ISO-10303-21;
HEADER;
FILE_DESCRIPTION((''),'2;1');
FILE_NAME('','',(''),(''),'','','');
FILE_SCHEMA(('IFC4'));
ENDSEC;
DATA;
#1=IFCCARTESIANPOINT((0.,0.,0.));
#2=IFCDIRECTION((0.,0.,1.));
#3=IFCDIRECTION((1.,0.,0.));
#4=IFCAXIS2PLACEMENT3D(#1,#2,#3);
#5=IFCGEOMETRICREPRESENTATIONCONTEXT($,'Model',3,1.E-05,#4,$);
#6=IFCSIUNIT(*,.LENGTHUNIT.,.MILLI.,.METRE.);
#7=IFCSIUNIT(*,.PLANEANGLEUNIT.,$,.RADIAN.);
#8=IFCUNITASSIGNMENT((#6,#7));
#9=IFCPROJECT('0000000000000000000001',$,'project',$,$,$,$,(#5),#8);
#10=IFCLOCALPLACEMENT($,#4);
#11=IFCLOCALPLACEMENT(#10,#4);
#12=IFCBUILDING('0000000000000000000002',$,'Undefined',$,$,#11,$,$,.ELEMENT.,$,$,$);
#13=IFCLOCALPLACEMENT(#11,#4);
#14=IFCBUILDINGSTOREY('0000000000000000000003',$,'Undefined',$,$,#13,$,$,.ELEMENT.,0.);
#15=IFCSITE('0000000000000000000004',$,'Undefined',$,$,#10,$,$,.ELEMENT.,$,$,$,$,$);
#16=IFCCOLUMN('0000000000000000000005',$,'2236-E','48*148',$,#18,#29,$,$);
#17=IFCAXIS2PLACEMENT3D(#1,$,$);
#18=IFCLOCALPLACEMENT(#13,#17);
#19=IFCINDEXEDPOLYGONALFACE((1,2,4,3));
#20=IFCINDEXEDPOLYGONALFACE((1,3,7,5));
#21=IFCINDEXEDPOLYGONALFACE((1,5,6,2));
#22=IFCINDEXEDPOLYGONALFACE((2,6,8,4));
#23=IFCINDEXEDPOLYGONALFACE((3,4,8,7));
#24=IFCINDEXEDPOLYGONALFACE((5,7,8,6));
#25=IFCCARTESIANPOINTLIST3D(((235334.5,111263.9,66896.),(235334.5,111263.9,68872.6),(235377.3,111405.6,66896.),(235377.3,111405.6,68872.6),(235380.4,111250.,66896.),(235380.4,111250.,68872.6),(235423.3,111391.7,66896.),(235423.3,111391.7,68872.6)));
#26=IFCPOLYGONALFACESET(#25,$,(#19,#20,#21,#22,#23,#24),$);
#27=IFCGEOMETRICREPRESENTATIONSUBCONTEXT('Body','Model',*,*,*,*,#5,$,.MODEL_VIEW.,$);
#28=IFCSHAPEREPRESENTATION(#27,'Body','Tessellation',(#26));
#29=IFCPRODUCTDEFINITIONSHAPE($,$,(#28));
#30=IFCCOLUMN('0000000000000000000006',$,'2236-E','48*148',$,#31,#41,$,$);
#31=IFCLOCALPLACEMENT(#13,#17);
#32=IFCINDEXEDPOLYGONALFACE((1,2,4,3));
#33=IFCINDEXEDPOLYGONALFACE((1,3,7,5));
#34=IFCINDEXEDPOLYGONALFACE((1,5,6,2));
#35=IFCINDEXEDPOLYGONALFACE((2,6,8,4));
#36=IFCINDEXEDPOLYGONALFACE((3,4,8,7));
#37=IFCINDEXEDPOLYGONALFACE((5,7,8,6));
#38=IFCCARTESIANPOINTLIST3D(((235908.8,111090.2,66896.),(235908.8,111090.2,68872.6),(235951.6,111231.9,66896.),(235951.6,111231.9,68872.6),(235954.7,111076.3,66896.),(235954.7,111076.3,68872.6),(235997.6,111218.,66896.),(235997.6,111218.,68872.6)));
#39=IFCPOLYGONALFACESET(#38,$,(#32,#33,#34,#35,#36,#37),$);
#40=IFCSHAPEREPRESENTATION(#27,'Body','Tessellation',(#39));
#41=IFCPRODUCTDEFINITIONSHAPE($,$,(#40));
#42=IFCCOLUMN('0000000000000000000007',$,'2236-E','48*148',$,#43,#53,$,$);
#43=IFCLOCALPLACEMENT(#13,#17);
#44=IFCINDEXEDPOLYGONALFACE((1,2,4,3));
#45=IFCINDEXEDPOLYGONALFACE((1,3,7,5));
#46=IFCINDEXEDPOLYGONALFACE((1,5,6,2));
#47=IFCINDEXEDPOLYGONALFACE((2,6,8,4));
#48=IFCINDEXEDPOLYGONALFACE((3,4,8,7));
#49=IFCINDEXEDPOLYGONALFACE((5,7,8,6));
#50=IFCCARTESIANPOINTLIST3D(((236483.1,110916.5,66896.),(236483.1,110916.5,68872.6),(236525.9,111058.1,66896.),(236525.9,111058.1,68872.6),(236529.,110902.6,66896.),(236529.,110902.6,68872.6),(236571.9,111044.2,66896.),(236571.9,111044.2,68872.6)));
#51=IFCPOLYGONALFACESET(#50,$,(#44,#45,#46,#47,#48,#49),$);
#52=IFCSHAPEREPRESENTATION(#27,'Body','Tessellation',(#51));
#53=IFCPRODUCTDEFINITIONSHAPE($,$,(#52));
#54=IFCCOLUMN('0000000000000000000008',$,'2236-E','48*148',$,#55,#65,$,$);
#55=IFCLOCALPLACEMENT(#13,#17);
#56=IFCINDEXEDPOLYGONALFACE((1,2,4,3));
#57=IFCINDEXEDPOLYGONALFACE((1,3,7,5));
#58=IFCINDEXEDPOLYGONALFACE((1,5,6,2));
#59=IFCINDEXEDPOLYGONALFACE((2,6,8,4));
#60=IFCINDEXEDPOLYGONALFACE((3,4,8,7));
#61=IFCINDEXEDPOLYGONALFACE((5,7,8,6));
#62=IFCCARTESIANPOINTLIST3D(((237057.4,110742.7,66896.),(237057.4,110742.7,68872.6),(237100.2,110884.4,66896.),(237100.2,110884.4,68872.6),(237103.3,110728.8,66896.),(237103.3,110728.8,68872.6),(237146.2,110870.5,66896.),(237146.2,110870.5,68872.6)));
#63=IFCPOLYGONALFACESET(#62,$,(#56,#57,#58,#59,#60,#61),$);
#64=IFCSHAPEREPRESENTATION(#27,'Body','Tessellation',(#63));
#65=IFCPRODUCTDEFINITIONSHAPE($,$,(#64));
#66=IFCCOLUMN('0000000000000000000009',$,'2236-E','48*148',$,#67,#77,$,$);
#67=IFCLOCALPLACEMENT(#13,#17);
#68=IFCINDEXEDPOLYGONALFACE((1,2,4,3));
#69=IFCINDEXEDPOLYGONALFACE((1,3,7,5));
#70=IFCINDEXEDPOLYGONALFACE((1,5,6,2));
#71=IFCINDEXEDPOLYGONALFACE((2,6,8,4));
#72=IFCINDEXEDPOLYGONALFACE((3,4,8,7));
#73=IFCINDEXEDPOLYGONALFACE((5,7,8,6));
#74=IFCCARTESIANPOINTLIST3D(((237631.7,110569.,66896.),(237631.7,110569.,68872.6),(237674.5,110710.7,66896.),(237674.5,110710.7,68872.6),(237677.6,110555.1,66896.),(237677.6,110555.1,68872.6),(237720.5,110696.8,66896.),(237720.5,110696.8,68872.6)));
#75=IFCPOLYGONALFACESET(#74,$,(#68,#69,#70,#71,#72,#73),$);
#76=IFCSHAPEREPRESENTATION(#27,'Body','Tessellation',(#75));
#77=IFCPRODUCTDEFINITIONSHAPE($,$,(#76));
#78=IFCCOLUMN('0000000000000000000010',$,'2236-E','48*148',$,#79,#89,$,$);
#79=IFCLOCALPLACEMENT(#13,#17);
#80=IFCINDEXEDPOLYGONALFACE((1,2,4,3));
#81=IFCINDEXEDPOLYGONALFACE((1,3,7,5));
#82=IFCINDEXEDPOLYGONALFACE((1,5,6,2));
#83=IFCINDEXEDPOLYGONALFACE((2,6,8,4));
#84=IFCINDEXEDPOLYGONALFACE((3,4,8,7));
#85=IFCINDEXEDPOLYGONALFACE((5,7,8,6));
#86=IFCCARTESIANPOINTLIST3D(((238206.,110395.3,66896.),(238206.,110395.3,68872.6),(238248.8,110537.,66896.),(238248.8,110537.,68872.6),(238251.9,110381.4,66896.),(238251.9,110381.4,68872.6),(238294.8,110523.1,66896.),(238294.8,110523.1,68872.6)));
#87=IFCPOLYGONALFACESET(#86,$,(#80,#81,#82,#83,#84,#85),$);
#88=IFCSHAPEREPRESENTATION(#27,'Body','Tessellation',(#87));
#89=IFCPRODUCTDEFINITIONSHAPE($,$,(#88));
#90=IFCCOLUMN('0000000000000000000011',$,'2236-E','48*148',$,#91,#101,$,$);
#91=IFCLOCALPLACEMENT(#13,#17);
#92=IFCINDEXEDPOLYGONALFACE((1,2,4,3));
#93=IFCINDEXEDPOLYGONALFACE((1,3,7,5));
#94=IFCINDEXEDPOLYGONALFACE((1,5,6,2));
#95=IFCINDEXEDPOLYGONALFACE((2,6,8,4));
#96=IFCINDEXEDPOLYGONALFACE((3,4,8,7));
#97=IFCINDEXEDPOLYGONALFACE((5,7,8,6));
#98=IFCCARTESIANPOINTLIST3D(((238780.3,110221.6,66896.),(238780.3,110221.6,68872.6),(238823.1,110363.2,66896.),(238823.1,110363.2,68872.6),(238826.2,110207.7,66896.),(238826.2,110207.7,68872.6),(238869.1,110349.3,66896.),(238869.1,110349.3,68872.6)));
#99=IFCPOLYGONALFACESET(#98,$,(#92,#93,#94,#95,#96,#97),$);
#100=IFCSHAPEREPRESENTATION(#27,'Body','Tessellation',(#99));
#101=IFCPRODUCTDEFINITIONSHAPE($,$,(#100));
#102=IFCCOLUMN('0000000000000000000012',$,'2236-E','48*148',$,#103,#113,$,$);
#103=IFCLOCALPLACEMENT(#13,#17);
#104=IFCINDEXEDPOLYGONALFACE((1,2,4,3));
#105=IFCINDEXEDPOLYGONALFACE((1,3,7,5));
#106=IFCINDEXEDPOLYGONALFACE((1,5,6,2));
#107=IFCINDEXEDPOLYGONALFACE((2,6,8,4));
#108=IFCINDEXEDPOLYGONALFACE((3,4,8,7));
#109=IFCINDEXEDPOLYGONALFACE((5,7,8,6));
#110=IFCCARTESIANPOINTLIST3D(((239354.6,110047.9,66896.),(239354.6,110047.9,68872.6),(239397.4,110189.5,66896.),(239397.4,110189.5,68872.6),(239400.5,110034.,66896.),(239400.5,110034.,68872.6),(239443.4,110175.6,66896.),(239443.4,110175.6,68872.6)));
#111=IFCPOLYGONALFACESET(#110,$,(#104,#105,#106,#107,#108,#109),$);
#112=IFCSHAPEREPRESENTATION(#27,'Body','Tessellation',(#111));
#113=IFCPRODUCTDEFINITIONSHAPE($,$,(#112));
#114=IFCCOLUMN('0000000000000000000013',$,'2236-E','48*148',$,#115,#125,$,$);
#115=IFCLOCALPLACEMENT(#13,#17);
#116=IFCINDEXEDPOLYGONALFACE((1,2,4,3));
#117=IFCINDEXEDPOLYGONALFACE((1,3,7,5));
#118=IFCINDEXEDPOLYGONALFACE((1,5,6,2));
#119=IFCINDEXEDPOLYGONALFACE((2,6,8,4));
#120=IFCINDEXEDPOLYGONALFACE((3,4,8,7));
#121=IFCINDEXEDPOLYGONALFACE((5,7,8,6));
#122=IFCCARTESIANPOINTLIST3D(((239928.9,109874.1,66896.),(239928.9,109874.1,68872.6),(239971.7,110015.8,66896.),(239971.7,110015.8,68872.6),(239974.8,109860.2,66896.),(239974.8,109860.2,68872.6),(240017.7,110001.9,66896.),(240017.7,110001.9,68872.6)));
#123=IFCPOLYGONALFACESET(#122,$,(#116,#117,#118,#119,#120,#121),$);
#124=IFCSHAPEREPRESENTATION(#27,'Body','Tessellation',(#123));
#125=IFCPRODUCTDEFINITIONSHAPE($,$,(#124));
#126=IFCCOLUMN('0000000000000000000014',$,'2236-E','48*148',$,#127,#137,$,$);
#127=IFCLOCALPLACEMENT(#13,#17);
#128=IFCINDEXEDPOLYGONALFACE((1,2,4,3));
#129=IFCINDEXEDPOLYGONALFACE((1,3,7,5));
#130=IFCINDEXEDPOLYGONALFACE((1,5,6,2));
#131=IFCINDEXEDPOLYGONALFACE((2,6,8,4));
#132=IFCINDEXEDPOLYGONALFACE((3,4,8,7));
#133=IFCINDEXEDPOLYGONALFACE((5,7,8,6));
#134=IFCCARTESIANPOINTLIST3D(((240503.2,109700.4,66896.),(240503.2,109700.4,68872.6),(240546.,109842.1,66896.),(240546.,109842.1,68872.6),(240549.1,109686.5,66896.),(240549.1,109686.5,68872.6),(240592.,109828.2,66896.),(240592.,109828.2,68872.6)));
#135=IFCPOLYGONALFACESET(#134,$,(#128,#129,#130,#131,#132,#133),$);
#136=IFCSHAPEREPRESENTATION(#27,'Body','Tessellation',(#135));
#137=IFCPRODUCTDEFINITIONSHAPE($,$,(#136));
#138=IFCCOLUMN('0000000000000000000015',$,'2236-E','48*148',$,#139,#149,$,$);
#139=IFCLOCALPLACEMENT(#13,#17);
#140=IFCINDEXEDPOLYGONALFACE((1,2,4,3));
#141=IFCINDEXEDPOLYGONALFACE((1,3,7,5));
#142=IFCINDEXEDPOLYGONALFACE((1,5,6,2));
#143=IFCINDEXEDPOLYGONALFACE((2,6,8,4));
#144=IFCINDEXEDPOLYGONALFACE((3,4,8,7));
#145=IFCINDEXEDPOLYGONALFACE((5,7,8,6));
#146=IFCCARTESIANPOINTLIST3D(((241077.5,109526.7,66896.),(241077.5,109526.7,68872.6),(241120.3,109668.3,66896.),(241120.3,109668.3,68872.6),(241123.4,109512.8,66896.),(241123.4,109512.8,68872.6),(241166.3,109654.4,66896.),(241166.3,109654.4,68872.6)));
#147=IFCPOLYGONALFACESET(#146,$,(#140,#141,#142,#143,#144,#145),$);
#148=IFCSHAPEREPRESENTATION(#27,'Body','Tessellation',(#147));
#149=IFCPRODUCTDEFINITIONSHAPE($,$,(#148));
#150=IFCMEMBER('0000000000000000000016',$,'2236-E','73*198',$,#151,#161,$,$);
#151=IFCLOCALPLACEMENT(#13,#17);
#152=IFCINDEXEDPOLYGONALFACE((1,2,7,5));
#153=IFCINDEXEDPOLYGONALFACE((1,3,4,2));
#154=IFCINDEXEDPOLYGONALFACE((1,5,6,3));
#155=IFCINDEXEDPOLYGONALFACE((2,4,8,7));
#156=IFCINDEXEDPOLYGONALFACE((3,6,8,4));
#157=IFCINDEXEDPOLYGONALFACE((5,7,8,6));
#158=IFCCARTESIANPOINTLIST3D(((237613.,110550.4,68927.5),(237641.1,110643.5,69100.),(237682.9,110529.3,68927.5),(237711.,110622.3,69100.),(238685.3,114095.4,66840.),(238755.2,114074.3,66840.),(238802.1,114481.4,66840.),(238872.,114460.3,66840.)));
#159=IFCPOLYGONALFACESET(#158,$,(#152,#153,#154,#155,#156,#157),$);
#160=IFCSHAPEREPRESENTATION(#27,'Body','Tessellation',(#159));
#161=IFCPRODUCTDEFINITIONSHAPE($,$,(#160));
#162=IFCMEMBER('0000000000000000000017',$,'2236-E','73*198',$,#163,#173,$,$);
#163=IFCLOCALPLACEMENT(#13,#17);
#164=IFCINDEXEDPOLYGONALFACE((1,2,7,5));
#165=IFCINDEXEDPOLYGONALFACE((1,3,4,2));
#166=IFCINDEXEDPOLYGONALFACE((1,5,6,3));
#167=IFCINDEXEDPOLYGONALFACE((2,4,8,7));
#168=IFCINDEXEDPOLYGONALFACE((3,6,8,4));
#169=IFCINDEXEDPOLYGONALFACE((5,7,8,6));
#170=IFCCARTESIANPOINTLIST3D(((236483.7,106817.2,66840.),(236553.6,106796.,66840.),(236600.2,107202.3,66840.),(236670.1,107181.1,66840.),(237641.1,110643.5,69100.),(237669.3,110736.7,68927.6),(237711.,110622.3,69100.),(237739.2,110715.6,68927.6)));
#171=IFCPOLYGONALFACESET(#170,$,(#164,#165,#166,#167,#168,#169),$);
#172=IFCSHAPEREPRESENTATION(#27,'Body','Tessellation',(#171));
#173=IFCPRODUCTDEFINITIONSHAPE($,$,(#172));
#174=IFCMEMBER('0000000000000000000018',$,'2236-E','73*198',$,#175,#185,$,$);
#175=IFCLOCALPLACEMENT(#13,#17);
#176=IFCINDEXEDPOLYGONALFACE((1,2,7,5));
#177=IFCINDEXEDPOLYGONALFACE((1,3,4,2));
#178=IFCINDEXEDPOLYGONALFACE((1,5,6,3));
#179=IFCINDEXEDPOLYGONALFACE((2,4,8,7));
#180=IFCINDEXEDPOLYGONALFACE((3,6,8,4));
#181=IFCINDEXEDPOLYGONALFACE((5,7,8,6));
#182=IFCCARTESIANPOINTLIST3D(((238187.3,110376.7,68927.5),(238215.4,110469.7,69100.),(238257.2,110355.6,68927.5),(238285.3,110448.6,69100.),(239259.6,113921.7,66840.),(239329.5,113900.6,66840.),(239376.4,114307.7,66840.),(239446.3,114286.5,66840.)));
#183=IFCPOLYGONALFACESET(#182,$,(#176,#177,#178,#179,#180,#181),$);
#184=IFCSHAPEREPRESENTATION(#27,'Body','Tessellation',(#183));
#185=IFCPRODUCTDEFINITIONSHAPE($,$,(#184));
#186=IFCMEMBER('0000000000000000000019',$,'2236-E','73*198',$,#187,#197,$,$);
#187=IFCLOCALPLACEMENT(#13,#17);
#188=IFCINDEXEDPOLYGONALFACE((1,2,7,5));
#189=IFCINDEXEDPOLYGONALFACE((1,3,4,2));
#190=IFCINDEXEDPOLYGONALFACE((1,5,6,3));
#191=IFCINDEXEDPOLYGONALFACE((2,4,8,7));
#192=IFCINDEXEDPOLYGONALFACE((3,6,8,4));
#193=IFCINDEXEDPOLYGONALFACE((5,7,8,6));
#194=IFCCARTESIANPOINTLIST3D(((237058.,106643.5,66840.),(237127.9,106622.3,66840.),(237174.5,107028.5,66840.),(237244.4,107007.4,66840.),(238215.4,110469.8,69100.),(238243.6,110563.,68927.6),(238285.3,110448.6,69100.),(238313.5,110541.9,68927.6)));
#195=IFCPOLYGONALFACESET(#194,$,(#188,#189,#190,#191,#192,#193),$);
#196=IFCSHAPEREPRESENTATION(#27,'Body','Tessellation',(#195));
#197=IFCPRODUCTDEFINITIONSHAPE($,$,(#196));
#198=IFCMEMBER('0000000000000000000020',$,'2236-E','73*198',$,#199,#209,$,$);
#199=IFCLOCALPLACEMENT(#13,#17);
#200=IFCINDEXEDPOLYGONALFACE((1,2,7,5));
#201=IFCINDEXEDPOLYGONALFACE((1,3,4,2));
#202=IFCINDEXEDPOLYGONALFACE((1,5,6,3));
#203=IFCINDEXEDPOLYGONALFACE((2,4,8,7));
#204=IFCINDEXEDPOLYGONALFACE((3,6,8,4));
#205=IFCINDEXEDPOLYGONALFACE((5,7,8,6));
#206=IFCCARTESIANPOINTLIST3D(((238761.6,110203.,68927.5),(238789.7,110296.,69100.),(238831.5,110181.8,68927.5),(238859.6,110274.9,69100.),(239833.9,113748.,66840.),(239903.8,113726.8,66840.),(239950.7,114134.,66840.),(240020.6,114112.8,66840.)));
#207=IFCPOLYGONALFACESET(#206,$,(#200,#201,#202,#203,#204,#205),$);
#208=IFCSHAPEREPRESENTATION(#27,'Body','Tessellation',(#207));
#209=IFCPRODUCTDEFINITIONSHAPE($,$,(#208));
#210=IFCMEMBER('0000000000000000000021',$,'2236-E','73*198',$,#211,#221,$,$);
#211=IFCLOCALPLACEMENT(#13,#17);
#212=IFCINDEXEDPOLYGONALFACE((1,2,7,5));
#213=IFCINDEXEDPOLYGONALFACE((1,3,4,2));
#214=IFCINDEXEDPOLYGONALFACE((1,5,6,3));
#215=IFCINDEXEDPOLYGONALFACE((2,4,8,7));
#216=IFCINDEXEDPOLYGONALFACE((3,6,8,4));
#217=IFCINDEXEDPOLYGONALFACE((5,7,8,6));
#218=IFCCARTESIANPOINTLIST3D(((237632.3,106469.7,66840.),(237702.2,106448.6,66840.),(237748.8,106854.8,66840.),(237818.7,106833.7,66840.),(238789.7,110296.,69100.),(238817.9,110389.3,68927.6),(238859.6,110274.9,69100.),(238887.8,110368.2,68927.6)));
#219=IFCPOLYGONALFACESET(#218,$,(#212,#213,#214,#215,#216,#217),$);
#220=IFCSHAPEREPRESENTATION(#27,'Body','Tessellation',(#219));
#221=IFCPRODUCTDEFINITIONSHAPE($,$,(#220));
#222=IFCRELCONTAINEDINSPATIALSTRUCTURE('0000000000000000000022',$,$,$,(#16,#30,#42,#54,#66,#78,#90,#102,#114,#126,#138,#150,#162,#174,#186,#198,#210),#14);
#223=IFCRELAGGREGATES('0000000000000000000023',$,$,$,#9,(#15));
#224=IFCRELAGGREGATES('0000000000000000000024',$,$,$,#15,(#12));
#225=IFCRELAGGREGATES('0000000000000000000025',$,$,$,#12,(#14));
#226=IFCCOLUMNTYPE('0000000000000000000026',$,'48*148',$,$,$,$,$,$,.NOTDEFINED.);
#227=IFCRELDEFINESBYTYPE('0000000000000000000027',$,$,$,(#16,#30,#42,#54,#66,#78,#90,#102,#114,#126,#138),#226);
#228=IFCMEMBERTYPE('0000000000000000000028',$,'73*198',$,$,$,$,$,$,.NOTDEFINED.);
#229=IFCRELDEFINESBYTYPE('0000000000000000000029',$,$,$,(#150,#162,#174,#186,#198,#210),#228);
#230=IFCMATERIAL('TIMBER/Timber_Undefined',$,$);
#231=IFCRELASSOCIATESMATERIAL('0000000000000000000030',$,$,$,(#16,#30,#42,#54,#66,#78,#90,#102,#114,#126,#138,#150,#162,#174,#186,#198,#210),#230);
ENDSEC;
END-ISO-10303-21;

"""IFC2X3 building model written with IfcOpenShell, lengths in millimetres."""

from ifc_helpers import new_model, si_unit, frame, origin_with_axes, origin_2d_with_axis, place, context, subcontext, project, spatial, rectangle, extrude, clip, halfspace, material, type_object, element, save


model = new_model("IFC2X3")

# Units and contexts
model_context = context("Model", 3, precision=1e-05, world=origin_with_axes())
body_context = subcontext(model_context, "Body", "Model", "MODEL_VIEW")
ifc_project = project(units=[si_unit("LENGTHUNIT", "METRE", prefix="MILLI"), si_unit("PLANEANGLEUNIT", "RADIAN")], contexts=[model_context])

# Site, building, storey
site_placement = place(None, origin_with_axes())
site = spatial("IfcSite", under=ifc_project, at=site_placement, Name="Undefined", CompositionType="ELEMENT")
building_placement = place(site_placement, origin_with_axes())
building = spatial("IfcBuilding", under=site, at=building_placement, Name="Undefined", CompositionType="ELEMENT")
storey_placement = place(building_placement, origin_with_axes())
storey = spatial("IfcBuildingStorey", under=building, at=storey_placement, Name="Undefined", CompositionType="ELEMENT", Elevation=0.0)

# Columns
ifc_material = material(Name="TIMBER/Timber_Undefined")
column_type = type_object("IfcColumnType", Name="48*148", PredefinedType="NOTDEFINED")
for number, where, z_axis, x_axis, name in (
    (1, (235378.9, 111327.8, 68872.6), (0.0, 0.0, -1.0), (0.957167, -0.289538, 0.0), "2236-E"),
    (2, (235953.2, 111154.1, 68872.6), (0.0, 0.0, -1.0), (0.957167, -0.289538, 0.0), "2236-E"),
    (3, (236527.5, 110980.3, 68872.6), (0.0, 0.0, -1.0), (0.957167, -0.289538, 0.0), "2236-E"),
    (4, (237101.8, 110806.6, 68872.6), (0.0, 0.0, -1.0), (0.957167, -0.289538, 0.0), "2236-E"),
    (5, (237676.1, 110632.9, 68872.6), (0.0, 0.0, -1.0), (0.957167, -0.289538, 0.0), "2236-E"),
    (6, (238250.4, 110459.2, 68872.6), (0.0, 0.0, -1.0), (0.957167, -0.289538, 0.0), "2236-E"),
    (7, (238824.7, 110285.5, 68872.6), (0.0, 0.0, -1.0), (0.957167, -0.289538, 0.0), "2236-E"),
    (8, (239399.0, 110111.7, 68872.6), (0.0, 0.0, -1.0), (0.957167, -0.289538, 0.0), "2236-E"),
    (9, (239973.3, 109938.0, 68872.6), (0.0, 0.0, -1.0), (0.957167, -0.289538, 0.0), "2236-E"),
    (10, (240547.6, 109764.3, 68872.6), (0.0, 0.0, -1.0), (0.957167, -0.289538, 0.0), "2236-E"),
    (11, (241121.9, 109590.6, 68872.6), (0.0, 0.0, -1.0), (0.957167, -0.289538, 0.0), "2236-E"),
):
    element("IfcColumn", number, at=place(storey_placement, frame(where, z_axis=z_axis, x_axis=x_axis)), inside=storey, type_object=column_type, material=ifc_material, Name=name, Description="48*148", context=body_context, shape_type="SweptSolid", body=[
        extrude(rectangle(XDim=148.0, YDim=48.0, at=origin_2d_with_axis()), frame((0.0, 0.0, 1976.6), z_axis=(0.0, 0.0, -1.0), x_axis=(0.0, 1.0, 0.0)), (0.0, 0.0, 1.0), 1976.6),
    ])

# Members
member_type = type_object("IfcMemberType", Name="73*198", PredefinedType="NOTDEFINED")
member_1_placement = place(storey_placement, frame((237662.0, 110586.4, 69013.8), z_axis=(-0.957167, 0.289538, 0.0), x_axis=(0.252232, 0.833838, -0.491013)))
element("IfcMember", 12, at=member_1_placement, inside=storey, type_object=member_type, material=ifc_material, Name="2236-E", Description="73*198", context=body_context, shape_type="Clipping", body=[
    clip(extrude(rectangle(XDim=198.0, YDim=73.0, at=origin_2d_with_axis()), frame((9470.2, 0.0, 0.0), z_axis=(-1.0, 0.0, 0.0), x_axis=(0.0, -1.0, 0.0)), (0.0, 0.0, 1.0), 9470.2), halfspace(frame((4746.2, -179.9, -36.5), z_axis=(0.491013, 0.871152, 0.0), x_axis=(0.0, 0.0, 1.0)), False)),
])
member_2_placement = place(storey_placement, frame((237690.2, 110679.5, 69013.8), z_axis=(-0.957167, 0.289538, 0.0), x_axis=(-0.252047, -0.833226, -0.492144)))
element("IfcMember", 13, at=member_2_placement, inside=storey, type_object=member_type, material=ifc_material, Name="2236-E", Description="73*198", context=body_context, shape_type="Clipping", body=[
    clip(extrude(rectangle(XDim=198.0, YDim=73.0, at=origin_2d_with_axis()), frame((9448.4, 0.0, 0.0), z_axis=(-1.0, 0.0, 0.0), x_axis=(0.0, -1.0, 0.0)), (0.0, 0.0, 1.0), 9448.5), halfspace(frame((4746.1, 186.1, 36.5), z_axis=(0.492144, -0.870514, 0.0), x_axis=(0.0, 0.0, -1.0)), False)),
])
member_3_placement = place(storey_placement, frame((238236.3, 110412.7, 69013.8), z_axis=(-0.957167, 0.289538, 0.0), x_axis=(0.252232, 0.833838, -0.491013)))
element("IfcMember", 14, at=member_3_placement, inside=storey, type_object=member_type, material=ifc_material, Name="2236-E", Description="73*198", context=body_context, shape_type="Clipping", body=[
    clip(extrude(rectangle(XDim=198.0, YDim=73.0, at=origin_2d_with_axis()), frame((9470.2, 0.0, 0.0), z_axis=(-1.0, 0.0, 0.0), x_axis=(0.0, -1.0, 0.0)), (0.0, 0.0, 1.0), 9470.2), halfspace(frame((4746.2, -179.9, -36.5), z_axis=(0.491013, 0.871152, 0.0), x_axis=(0.0, 0.0, 1.0)), False)),
])
member_4_placement = place(storey_placement, frame((238264.5, 110505.8, 69013.8), z_axis=(-0.957167, 0.289538, 0.0), x_axis=(-0.252047, -0.833226, -0.492144)))
element("IfcMember", 15, at=member_4_placement, inside=storey, type_object=member_type, material=ifc_material, Name="2236-E", Description="73*198", context=body_context, shape_type="Clipping", body=[
    clip(extrude(rectangle(XDim=198.0, YDim=73.0, at=origin_2d_with_axis()), frame((9448.4, 0.0, 0.0), z_axis=(-1.0, 0.0, 0.0), x_axis=(0.0, -1.0, 0.0)), (0.0, 0.0, 1.0), 9448.5), halfspace(frame((4746.1, 186.1, 36.5), z_axis=(0.492144, -0.870514, 0.0), x_axis=(0.0, 0.0, -1.0)), False)),
])
member_5_placement = place(storey_placement, frame((238810.6, 110238.9, 69013.8), z_axis=(-0.957167, 0.289538, 0.0), x_axis=(0.252232, 0.833838, -0.491013)))
element("IfcMember", 16, at=member_5_placement, inside=storey, type_object=member_type, material=ifc_material, Name="2236-E", Description="73*198", context=body_context, shape_type="Clipping", body=[
    clip(extrude(rectangle(XDim=198.0, YDim=73.0, at=origin_2d_with_axis()), frame((9470.2, 0.0, 0.0), z_axis=(-1.0, 0.0, 0.0), x_axis=(0.0, -1.0, 0.0)), (0.0, 0.0, 1.0), 9470.2), halfspace(frame((4746.2, -179.9, -36.5), z_axis=(0.491013, 0.871152, 0.0), x_axis=(0.0, 0.0, 1.0)), False)),
])
member_6_placement = place(storey_placement, frame((238838.8, 110332.1, 69013.8), z_axis=(-0.957167, 0.289538, 0.0), x_axis=(-0.252047, -0.833226, -0.492144)))
element("IfcMember", 17, at=member_6_placement, inside=storey, type_object=member_type, material=ifc_material, Name="2236-E", Description="73*198", context=body_context, shape_type="Clipping", body=[
    clip(extrude(rectangle(XDim=198.0, YDim=73.0, at=origin_2d_with_axis()), frame((9448.4, 0.0, 0.0), z_axis=(-1.0, 0.0, 0.0), x_axis=(0.0, -1.0, 0.0)), (0.0, 0.0, 1.0), 9448.5), halfspace(frame((4746.1, 186.1, 36.5), z_axis=(0.492144, -0.870514, 0.0), x_axis=(0.0, 0.0, -1.0)), False)),
])

save(model, "model.ifc")
